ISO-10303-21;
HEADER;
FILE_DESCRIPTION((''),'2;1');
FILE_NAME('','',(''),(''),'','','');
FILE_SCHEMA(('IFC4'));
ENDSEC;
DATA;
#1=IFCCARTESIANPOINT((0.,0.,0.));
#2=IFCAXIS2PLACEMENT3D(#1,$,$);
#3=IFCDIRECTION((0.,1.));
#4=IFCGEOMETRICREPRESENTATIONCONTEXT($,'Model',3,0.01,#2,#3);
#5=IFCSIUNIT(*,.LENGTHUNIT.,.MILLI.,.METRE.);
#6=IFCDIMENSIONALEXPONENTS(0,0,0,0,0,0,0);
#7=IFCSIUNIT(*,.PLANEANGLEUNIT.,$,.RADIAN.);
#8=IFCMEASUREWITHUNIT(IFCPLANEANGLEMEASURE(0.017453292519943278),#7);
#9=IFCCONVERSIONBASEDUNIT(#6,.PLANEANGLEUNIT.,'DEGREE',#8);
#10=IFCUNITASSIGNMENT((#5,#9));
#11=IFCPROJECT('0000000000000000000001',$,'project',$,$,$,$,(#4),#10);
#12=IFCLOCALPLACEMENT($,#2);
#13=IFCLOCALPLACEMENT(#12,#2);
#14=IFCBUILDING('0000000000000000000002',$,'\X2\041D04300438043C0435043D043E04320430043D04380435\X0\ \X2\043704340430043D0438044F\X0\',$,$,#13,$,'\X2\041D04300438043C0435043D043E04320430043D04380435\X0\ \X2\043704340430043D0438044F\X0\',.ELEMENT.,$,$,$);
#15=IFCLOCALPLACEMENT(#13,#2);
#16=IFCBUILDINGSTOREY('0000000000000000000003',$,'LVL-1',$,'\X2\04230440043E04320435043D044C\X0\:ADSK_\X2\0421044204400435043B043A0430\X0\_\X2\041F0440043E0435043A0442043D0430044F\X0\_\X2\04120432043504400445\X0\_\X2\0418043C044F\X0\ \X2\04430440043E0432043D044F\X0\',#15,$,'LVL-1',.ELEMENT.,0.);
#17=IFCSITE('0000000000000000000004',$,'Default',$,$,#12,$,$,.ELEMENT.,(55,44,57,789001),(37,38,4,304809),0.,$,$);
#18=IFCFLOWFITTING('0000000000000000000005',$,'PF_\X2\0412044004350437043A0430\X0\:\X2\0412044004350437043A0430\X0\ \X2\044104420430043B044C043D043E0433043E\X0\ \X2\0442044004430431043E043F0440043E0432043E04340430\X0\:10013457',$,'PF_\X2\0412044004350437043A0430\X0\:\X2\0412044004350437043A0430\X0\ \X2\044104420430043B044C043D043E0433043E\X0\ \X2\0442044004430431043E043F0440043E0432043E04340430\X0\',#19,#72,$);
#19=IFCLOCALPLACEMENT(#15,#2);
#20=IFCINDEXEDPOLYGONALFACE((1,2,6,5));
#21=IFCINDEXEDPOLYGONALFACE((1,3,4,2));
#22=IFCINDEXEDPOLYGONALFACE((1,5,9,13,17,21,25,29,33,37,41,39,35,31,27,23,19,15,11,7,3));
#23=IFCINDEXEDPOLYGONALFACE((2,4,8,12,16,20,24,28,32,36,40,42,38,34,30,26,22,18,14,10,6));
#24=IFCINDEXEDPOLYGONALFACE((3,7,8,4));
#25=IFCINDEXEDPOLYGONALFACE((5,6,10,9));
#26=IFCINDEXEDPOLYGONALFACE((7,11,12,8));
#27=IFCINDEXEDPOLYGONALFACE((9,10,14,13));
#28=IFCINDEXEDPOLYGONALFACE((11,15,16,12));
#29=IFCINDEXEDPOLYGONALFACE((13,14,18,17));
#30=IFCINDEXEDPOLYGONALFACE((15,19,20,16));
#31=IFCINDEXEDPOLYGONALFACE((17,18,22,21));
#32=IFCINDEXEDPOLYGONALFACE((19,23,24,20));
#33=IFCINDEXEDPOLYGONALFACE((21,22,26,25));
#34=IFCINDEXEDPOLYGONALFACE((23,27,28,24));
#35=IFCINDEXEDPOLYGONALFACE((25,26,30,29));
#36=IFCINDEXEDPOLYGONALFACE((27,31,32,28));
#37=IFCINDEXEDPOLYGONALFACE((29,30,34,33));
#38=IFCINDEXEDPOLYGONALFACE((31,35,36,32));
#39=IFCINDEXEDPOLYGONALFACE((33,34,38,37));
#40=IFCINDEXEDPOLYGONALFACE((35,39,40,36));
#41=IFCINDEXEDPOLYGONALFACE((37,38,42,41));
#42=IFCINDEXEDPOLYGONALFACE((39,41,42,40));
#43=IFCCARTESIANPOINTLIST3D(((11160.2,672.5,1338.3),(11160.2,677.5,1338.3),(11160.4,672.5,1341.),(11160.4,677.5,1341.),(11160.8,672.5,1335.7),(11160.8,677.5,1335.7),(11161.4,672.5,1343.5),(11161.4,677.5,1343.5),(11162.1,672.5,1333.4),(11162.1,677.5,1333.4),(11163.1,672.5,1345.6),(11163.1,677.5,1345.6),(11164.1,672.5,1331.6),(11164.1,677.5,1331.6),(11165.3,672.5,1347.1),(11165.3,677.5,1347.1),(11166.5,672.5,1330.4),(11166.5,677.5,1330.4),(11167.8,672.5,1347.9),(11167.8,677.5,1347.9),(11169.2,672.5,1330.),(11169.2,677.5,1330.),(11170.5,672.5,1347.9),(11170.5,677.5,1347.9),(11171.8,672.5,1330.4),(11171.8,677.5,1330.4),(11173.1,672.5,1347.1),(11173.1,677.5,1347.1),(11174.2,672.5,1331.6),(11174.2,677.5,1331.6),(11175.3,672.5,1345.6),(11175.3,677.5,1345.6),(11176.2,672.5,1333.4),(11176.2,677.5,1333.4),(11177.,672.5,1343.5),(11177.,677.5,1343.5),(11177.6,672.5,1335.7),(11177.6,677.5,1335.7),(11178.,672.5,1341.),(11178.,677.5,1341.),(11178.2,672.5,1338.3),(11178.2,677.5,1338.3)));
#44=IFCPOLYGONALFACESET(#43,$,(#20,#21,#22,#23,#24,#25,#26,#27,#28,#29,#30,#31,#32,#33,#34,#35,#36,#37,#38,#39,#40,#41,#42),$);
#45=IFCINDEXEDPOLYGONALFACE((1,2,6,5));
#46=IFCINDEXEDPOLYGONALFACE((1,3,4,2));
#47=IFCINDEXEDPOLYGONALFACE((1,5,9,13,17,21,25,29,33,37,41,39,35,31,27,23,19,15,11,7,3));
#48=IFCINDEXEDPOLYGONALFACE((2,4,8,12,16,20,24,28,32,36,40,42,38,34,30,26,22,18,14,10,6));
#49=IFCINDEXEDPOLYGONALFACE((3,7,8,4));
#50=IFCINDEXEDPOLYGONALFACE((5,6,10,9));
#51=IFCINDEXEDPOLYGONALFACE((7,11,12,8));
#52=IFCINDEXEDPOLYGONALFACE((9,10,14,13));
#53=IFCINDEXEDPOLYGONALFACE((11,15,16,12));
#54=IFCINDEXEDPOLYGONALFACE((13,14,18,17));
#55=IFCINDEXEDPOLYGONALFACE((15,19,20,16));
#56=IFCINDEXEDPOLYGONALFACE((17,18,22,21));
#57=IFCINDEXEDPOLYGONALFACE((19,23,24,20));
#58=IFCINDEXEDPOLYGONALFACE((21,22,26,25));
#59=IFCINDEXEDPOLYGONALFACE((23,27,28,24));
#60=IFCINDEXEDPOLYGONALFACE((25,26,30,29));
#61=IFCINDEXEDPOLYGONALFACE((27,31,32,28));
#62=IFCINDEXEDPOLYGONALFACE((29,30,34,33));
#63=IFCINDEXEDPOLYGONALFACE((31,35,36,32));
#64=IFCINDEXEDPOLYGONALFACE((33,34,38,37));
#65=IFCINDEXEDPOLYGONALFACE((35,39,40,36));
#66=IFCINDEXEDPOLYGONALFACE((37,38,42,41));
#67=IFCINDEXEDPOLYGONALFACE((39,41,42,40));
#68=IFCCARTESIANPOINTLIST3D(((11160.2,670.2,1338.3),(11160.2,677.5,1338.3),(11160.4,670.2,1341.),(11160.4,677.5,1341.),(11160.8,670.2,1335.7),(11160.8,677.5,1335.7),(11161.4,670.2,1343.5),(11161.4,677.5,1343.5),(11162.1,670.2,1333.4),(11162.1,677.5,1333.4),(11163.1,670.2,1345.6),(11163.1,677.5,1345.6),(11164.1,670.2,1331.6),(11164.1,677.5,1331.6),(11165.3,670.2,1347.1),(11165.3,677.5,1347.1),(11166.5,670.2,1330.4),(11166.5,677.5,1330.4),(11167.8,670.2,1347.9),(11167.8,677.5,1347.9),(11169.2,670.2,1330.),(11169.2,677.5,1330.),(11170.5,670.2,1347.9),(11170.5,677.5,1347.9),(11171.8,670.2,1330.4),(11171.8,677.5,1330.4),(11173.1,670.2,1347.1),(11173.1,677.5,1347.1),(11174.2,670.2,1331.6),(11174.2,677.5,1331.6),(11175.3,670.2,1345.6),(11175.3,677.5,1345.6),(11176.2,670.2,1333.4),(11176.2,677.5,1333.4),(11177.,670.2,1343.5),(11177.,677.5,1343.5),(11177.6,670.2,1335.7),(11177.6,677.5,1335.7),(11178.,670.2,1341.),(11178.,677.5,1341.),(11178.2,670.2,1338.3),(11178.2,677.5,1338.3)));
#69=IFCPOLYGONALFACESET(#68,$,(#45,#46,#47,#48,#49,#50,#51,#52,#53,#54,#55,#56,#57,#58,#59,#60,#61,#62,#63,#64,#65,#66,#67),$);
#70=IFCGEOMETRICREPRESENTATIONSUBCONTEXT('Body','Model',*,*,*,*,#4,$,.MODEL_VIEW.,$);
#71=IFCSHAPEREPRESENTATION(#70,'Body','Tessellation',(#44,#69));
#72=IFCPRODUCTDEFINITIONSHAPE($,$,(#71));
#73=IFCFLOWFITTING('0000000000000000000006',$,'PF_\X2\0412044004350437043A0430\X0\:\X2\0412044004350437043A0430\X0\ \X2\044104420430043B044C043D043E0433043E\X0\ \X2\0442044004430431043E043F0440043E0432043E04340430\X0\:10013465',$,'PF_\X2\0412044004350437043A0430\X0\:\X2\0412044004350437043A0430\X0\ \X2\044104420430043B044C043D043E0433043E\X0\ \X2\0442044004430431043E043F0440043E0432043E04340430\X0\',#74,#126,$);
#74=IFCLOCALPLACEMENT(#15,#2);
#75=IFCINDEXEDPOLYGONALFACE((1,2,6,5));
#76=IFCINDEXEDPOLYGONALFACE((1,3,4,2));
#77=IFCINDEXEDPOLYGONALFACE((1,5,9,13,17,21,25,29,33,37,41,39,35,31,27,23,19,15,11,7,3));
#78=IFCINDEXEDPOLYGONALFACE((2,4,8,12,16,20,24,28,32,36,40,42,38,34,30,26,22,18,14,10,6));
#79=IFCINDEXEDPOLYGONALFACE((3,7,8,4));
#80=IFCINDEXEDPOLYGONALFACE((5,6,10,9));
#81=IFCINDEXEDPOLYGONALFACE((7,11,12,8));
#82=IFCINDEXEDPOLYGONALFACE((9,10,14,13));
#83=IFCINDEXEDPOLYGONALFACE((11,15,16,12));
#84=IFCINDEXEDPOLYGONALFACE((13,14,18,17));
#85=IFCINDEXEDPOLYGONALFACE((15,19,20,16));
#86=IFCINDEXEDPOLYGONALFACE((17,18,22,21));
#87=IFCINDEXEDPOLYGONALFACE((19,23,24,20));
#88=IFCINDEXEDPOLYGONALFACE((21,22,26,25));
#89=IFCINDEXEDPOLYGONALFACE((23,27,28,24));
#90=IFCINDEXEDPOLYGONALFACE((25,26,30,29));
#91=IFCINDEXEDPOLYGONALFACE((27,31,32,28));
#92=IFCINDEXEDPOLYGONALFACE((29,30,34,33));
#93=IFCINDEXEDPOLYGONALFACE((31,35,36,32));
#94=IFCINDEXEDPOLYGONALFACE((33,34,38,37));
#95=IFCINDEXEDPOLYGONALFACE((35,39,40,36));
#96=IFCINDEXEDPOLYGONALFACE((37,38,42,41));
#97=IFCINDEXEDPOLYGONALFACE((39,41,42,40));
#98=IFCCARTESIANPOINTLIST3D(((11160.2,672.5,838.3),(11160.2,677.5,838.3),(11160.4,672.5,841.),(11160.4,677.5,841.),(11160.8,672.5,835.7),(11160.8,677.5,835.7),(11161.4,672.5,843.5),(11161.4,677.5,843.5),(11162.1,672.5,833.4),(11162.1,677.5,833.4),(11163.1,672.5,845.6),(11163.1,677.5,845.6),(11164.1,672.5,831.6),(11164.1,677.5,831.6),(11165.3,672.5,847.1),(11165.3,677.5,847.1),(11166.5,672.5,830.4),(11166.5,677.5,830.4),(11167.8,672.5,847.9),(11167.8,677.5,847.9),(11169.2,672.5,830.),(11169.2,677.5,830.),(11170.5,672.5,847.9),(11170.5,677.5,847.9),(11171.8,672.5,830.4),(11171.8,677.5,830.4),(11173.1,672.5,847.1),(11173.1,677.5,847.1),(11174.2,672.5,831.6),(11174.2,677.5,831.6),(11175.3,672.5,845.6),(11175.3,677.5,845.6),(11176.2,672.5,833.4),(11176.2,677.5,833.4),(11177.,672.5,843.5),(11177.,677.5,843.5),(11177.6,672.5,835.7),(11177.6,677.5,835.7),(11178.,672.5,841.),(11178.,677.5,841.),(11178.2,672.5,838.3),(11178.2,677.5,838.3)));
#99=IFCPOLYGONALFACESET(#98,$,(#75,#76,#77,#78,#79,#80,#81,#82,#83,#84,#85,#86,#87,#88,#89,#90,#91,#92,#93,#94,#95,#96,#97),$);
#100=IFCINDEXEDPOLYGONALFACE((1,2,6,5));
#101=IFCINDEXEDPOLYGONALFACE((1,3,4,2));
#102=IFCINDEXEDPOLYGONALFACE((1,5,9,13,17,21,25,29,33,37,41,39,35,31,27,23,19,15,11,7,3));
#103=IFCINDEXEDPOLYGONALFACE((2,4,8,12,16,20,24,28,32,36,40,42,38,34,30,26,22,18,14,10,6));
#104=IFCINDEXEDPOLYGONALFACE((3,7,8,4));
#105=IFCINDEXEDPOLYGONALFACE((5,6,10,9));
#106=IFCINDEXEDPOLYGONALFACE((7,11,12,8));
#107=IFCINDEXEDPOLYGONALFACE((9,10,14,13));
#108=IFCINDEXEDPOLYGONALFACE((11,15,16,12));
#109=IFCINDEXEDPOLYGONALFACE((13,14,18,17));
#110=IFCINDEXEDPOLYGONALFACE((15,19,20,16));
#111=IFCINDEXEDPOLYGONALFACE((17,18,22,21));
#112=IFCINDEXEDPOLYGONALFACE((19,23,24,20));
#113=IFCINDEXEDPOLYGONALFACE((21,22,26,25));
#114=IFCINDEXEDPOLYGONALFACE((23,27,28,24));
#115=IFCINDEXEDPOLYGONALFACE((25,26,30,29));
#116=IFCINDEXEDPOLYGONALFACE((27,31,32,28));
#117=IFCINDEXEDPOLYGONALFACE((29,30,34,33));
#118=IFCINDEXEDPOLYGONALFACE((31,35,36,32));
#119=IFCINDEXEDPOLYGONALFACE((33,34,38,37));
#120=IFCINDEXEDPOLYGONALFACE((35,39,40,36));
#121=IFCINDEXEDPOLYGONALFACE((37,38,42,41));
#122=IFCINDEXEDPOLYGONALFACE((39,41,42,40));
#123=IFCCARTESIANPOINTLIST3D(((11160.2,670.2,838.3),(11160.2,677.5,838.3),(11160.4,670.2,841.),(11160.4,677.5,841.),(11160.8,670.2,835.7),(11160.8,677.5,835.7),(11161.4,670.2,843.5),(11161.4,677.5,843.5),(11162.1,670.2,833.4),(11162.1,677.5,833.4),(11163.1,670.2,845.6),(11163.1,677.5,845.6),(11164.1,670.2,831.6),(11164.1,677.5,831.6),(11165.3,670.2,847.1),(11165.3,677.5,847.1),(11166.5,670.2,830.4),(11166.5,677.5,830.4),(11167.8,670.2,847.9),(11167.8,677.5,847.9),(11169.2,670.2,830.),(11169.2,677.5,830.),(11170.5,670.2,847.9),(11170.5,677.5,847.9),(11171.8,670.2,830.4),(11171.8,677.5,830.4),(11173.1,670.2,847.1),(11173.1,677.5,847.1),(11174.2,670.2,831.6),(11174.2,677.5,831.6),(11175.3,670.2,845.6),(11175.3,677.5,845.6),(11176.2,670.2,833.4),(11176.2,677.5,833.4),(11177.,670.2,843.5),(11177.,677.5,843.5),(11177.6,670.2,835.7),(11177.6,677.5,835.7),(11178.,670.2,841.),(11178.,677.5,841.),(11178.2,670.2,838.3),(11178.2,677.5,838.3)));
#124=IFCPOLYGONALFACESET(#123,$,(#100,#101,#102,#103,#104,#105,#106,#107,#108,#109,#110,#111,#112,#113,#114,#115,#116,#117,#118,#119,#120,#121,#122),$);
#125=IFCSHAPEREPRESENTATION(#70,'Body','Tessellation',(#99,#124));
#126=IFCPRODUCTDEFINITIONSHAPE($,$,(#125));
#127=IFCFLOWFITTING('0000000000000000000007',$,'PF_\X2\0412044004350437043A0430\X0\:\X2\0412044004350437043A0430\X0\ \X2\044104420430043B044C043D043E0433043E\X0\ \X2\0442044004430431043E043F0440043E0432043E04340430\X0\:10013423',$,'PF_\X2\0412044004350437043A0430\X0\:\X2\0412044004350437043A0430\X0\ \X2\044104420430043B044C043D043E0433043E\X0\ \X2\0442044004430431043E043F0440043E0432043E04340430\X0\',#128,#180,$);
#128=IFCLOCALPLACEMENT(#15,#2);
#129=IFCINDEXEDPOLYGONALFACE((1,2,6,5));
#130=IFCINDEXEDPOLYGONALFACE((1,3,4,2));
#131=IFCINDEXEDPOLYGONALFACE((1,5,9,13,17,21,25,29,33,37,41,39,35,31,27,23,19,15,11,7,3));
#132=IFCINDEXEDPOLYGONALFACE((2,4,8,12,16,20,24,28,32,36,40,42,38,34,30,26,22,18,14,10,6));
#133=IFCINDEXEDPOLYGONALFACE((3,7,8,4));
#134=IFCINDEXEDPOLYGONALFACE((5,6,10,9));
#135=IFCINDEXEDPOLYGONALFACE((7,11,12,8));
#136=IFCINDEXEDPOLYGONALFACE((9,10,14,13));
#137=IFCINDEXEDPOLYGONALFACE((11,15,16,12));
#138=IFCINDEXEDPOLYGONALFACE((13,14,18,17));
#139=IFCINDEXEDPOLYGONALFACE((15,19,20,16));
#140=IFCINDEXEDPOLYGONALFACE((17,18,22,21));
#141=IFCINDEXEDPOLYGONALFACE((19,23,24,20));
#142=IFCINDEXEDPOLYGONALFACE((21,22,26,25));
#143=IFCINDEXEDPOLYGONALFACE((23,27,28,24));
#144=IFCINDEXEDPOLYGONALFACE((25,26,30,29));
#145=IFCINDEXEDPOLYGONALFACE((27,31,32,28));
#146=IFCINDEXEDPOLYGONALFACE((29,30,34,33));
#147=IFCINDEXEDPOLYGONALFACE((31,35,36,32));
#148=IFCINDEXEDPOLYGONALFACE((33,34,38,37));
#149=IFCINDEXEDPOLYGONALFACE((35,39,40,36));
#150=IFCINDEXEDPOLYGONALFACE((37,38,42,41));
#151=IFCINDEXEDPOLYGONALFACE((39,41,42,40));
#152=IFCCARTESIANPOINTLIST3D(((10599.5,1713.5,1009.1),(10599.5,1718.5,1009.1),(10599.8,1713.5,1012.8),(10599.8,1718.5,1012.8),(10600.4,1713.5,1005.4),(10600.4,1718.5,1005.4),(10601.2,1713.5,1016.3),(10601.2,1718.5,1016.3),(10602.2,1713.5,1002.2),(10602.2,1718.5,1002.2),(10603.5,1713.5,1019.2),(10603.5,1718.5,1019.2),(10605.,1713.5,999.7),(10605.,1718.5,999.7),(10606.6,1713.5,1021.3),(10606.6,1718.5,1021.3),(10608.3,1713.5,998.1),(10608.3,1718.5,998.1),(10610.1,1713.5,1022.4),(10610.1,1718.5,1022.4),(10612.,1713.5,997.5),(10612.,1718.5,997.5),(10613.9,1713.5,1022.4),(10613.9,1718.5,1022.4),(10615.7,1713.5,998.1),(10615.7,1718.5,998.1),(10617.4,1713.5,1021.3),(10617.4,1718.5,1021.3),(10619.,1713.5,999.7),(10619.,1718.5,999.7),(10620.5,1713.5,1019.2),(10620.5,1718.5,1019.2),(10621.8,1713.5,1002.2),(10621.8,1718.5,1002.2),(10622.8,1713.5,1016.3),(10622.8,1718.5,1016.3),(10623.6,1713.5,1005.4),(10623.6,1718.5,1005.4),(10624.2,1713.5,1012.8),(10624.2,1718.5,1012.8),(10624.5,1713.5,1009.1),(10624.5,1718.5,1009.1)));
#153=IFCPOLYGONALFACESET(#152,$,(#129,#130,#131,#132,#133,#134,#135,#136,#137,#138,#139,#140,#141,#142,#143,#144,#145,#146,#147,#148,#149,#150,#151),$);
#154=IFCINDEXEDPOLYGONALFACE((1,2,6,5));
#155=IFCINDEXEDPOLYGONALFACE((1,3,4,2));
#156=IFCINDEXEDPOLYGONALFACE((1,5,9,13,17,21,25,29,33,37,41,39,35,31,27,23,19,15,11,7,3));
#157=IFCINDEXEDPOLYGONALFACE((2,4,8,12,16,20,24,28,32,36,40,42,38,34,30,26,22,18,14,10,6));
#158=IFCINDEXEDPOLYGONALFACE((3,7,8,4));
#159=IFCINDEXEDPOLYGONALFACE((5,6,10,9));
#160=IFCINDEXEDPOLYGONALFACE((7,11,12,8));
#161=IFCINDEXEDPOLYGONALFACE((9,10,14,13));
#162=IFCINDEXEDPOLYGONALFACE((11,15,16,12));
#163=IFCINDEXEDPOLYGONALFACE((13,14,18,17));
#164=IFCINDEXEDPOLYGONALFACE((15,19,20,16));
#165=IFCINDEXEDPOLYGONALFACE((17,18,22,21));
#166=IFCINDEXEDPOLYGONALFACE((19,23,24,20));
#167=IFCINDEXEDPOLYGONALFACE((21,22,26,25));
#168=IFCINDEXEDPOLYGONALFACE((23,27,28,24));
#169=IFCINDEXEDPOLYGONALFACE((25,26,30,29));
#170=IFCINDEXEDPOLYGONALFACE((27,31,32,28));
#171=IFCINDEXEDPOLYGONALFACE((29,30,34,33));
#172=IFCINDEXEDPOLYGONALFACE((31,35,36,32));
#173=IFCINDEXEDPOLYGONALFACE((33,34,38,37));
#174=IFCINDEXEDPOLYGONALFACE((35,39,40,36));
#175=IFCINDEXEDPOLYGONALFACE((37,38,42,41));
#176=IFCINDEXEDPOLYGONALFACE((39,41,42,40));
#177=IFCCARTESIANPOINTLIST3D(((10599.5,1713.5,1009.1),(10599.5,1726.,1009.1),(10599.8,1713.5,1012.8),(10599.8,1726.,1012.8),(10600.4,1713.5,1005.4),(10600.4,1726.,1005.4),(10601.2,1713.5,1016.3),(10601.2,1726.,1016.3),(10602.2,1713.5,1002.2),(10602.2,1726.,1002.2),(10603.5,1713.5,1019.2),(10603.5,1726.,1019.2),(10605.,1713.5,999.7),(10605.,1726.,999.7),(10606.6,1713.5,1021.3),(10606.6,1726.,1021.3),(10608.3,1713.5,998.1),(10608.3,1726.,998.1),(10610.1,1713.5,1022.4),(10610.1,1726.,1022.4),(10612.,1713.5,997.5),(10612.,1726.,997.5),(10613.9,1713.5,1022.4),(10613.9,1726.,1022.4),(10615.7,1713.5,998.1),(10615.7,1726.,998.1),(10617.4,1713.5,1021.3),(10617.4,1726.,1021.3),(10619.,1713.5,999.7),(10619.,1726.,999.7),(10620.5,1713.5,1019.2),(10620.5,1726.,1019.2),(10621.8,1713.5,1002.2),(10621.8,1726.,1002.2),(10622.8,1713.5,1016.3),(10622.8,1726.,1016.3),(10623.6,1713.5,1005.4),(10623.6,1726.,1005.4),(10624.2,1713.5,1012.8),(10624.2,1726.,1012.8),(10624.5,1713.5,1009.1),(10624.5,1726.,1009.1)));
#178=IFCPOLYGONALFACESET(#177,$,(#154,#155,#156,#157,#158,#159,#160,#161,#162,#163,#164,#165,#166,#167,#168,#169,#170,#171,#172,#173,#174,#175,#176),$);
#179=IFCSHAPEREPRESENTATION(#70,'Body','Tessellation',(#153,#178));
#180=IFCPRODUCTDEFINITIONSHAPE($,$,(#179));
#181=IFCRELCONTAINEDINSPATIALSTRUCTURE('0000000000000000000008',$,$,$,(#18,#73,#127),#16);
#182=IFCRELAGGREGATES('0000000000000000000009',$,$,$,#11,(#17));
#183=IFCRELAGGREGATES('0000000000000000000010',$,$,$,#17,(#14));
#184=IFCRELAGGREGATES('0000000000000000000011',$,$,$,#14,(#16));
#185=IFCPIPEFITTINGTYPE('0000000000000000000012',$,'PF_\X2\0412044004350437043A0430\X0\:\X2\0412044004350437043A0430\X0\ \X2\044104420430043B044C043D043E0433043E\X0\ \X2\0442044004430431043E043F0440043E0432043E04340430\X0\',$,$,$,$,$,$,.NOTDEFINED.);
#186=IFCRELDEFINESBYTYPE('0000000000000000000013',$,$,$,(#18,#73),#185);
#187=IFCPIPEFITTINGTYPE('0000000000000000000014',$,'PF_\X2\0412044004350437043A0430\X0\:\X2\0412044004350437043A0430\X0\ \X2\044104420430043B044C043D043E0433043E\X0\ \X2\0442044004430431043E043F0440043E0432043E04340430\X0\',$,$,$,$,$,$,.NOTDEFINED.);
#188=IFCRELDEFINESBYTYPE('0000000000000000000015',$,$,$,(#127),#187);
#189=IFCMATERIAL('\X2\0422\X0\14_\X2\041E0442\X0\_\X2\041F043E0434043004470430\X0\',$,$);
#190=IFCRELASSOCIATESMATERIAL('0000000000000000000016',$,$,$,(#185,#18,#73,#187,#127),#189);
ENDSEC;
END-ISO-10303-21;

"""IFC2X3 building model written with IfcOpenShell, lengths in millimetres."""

from ifc_helpers import new_model, entity, si_unit, converted_unit, direction, frame, frame_2d, origin, place, context, subcontext, project, spatial, circle, extrude, source, transform, mapped, material, type_object, type_shapes, element, save


model = new_model("IFC2X3")

# Units and contexts
model_context = context("Model", 3, precision=0.01, world=origin(), true_north=direction((0.0, 1.0)))
body_context = subcontext(model_context, "Body", "Model", "MODEL_VIEW")
ifc_project = project(units=[si_unit("LENGTHUNIT", "METRE", prefix="MILLI"), converted_unit("PLANEANGLEUNIT", "DEGREE", entity("IfcPlaneAngleMeasure", 0.017453292519943278), si_unit("PLANEANGLEUNIT", "RADIAN"), dimensions=[0, 0, 0, 0, 0, 0, 0])], contexts=[model_context])

# Site, building, storey
site_placement = place(None, origin())
site = spatial("IfcSite", under=ifc_project, at=site_placement, Name="Default", CompositionType="ELEMENT", RefLatitude=(55, 44, 57, 789001), RefLongitude=(37, 38, 4, 304809), RefElevation=0.0)
building_placement = place(site_placement, origin())
building = spatial("IfcBuilding", under=site, at=building_placement, Name="Наименование здания", LongName="Наименование здания", CompositionType="ELEMENT")
storey_placement = place(building_placement, origin())
storey = spatial("IfcBuildingStorey", under=building, at=storey_placement, Name="LVL-1", ObjectType="Уровень:ADSK_Стрелка_Проектная_Вверх_Имя уровня", LongName="LVL-1", CompositionType="ELEMENT", Elevation=0.0)

# Flow fittings
ifc_material_1 = material(Name="Т14_От_Подача")
pipe_fitting_type_1 = type_object("IfcPipeFittingType", Name="PF_Врезка:Врезка стального трубопровода", PredefinedType="NOTDEFINED", material=ifc_material_1)
shared_shape_1 = source(origin(), body_context, "Body", "SweptSolid", [
    extrude(circle(Radius=9.0, at=frame_2d((0.0, 0.0), x_axis=(1.0, 0.0))), frame((-5.0, 0.0, 0.0), z_axis=(1.0, 0.0, 0.0), x_axis=(0.0, -1.0, 0.0)), (0.0, 0.0, 1.0), 5.0),
    extrude(circle(Radius=9.0, at=frame_2d((0.0, 0.0), x_axis=(1.0, 0.0))), frame((-7.3, 0.0, 0.0), z_axis=(1.0, 0.0, 0.0), x_axis=(0.0, -1.0, 0.0)), (0.0, 0.0, 1.0), 7.3),
])
type_shapes(pipe_fitting_type_1, [shared_shape_1])
for number, where, z_axis, x_axis, name in (
    (1, (11169.2, 677.5, 1339.0), (1.0, 0.0, 0.0), (0.0, 1.0, 0.0), "PF_Врезка:Врезка стального трубопровода:10013457"),
    (2, (11169.2, 677.5, 839.0), (1.0, 0.0, 0.0), (0.0, 1.0, 0.0), "PF_Врезка:Врезка стального трубопровода:10013465"),
):
    element("IfcFlowFitting", number, at=place(storey_placement, frame(where, z_axis=z_axis, x_axis=x_axis)), inside=storey, type_object=pipe_fitting_type_1, material=ifc_material_1, Name=name, ObjectType="PF_Врезка:Врезка стального трубопровода", context=body_context, shape_type="MappedRepresentation", body=[
        mapped(shared_shape_1, transform((0.0, 0.0, 0.0), scale=1.0)),
    ])
pipe_fitting_type_2 = type_object("IfcPipeFittingType", Name="PF_Врезка:Врезка стального трубопровода", PredefinedType="NOTDEFINED", material=ifc_material_1)
shared_shape_2 = source(origin(), body_context, "Body", "SweptSolid", [
    extrude(circle(Radius=12.5, at=frame_2d((0.0, 0.0), x_axis=(1.0, 0.0))), frame((-5.0, 0.0, 0.0), z_axis=(1.0, 0.0, 0.0), x_axis=(0.0, -1.0, 0.0)), (0.0, 0.0, 1.0), 5.0),
    extrude(circle(Radius=12.5, at=frame_2d((0.0, 0.0), x_axis=(1.0, 0.0))), frame((-12.5, 0.0, 0.0), z_axis=(1.0, 0.0, 0.0), x_axis=(0.0, -1.0, 0.0)), (0.0, 0.0, 1.0), 12.5),
])
type_shapes(pipe_fitting_type_2, [shared_shape_2])
flow_fitting_1_placement = place(storey_placement, frame((10612.0, 1713.5, 1010.0), z_axis=(-1.0, 0.0, 0.0), x_axis=(0.0, -1.0, 0.0)))
element("IfcFlowFitting", 3, at=flow_fitting_1_placement, inside=storey, type_object=pipe_fitting_type_2, material=ifc_material_1, Name="PF_Врезка:Врезка стального трубопровода:10013423", ObjectType="PF_Врезка:Врезка стального трубопровода", context=body_context, shape_type="MappedRepresentation", body=[
    mapped(shared_shape_2, transform((0.0, 0.0, 0.0), scale=1.0)),
])

save(model, "model.ifc")
